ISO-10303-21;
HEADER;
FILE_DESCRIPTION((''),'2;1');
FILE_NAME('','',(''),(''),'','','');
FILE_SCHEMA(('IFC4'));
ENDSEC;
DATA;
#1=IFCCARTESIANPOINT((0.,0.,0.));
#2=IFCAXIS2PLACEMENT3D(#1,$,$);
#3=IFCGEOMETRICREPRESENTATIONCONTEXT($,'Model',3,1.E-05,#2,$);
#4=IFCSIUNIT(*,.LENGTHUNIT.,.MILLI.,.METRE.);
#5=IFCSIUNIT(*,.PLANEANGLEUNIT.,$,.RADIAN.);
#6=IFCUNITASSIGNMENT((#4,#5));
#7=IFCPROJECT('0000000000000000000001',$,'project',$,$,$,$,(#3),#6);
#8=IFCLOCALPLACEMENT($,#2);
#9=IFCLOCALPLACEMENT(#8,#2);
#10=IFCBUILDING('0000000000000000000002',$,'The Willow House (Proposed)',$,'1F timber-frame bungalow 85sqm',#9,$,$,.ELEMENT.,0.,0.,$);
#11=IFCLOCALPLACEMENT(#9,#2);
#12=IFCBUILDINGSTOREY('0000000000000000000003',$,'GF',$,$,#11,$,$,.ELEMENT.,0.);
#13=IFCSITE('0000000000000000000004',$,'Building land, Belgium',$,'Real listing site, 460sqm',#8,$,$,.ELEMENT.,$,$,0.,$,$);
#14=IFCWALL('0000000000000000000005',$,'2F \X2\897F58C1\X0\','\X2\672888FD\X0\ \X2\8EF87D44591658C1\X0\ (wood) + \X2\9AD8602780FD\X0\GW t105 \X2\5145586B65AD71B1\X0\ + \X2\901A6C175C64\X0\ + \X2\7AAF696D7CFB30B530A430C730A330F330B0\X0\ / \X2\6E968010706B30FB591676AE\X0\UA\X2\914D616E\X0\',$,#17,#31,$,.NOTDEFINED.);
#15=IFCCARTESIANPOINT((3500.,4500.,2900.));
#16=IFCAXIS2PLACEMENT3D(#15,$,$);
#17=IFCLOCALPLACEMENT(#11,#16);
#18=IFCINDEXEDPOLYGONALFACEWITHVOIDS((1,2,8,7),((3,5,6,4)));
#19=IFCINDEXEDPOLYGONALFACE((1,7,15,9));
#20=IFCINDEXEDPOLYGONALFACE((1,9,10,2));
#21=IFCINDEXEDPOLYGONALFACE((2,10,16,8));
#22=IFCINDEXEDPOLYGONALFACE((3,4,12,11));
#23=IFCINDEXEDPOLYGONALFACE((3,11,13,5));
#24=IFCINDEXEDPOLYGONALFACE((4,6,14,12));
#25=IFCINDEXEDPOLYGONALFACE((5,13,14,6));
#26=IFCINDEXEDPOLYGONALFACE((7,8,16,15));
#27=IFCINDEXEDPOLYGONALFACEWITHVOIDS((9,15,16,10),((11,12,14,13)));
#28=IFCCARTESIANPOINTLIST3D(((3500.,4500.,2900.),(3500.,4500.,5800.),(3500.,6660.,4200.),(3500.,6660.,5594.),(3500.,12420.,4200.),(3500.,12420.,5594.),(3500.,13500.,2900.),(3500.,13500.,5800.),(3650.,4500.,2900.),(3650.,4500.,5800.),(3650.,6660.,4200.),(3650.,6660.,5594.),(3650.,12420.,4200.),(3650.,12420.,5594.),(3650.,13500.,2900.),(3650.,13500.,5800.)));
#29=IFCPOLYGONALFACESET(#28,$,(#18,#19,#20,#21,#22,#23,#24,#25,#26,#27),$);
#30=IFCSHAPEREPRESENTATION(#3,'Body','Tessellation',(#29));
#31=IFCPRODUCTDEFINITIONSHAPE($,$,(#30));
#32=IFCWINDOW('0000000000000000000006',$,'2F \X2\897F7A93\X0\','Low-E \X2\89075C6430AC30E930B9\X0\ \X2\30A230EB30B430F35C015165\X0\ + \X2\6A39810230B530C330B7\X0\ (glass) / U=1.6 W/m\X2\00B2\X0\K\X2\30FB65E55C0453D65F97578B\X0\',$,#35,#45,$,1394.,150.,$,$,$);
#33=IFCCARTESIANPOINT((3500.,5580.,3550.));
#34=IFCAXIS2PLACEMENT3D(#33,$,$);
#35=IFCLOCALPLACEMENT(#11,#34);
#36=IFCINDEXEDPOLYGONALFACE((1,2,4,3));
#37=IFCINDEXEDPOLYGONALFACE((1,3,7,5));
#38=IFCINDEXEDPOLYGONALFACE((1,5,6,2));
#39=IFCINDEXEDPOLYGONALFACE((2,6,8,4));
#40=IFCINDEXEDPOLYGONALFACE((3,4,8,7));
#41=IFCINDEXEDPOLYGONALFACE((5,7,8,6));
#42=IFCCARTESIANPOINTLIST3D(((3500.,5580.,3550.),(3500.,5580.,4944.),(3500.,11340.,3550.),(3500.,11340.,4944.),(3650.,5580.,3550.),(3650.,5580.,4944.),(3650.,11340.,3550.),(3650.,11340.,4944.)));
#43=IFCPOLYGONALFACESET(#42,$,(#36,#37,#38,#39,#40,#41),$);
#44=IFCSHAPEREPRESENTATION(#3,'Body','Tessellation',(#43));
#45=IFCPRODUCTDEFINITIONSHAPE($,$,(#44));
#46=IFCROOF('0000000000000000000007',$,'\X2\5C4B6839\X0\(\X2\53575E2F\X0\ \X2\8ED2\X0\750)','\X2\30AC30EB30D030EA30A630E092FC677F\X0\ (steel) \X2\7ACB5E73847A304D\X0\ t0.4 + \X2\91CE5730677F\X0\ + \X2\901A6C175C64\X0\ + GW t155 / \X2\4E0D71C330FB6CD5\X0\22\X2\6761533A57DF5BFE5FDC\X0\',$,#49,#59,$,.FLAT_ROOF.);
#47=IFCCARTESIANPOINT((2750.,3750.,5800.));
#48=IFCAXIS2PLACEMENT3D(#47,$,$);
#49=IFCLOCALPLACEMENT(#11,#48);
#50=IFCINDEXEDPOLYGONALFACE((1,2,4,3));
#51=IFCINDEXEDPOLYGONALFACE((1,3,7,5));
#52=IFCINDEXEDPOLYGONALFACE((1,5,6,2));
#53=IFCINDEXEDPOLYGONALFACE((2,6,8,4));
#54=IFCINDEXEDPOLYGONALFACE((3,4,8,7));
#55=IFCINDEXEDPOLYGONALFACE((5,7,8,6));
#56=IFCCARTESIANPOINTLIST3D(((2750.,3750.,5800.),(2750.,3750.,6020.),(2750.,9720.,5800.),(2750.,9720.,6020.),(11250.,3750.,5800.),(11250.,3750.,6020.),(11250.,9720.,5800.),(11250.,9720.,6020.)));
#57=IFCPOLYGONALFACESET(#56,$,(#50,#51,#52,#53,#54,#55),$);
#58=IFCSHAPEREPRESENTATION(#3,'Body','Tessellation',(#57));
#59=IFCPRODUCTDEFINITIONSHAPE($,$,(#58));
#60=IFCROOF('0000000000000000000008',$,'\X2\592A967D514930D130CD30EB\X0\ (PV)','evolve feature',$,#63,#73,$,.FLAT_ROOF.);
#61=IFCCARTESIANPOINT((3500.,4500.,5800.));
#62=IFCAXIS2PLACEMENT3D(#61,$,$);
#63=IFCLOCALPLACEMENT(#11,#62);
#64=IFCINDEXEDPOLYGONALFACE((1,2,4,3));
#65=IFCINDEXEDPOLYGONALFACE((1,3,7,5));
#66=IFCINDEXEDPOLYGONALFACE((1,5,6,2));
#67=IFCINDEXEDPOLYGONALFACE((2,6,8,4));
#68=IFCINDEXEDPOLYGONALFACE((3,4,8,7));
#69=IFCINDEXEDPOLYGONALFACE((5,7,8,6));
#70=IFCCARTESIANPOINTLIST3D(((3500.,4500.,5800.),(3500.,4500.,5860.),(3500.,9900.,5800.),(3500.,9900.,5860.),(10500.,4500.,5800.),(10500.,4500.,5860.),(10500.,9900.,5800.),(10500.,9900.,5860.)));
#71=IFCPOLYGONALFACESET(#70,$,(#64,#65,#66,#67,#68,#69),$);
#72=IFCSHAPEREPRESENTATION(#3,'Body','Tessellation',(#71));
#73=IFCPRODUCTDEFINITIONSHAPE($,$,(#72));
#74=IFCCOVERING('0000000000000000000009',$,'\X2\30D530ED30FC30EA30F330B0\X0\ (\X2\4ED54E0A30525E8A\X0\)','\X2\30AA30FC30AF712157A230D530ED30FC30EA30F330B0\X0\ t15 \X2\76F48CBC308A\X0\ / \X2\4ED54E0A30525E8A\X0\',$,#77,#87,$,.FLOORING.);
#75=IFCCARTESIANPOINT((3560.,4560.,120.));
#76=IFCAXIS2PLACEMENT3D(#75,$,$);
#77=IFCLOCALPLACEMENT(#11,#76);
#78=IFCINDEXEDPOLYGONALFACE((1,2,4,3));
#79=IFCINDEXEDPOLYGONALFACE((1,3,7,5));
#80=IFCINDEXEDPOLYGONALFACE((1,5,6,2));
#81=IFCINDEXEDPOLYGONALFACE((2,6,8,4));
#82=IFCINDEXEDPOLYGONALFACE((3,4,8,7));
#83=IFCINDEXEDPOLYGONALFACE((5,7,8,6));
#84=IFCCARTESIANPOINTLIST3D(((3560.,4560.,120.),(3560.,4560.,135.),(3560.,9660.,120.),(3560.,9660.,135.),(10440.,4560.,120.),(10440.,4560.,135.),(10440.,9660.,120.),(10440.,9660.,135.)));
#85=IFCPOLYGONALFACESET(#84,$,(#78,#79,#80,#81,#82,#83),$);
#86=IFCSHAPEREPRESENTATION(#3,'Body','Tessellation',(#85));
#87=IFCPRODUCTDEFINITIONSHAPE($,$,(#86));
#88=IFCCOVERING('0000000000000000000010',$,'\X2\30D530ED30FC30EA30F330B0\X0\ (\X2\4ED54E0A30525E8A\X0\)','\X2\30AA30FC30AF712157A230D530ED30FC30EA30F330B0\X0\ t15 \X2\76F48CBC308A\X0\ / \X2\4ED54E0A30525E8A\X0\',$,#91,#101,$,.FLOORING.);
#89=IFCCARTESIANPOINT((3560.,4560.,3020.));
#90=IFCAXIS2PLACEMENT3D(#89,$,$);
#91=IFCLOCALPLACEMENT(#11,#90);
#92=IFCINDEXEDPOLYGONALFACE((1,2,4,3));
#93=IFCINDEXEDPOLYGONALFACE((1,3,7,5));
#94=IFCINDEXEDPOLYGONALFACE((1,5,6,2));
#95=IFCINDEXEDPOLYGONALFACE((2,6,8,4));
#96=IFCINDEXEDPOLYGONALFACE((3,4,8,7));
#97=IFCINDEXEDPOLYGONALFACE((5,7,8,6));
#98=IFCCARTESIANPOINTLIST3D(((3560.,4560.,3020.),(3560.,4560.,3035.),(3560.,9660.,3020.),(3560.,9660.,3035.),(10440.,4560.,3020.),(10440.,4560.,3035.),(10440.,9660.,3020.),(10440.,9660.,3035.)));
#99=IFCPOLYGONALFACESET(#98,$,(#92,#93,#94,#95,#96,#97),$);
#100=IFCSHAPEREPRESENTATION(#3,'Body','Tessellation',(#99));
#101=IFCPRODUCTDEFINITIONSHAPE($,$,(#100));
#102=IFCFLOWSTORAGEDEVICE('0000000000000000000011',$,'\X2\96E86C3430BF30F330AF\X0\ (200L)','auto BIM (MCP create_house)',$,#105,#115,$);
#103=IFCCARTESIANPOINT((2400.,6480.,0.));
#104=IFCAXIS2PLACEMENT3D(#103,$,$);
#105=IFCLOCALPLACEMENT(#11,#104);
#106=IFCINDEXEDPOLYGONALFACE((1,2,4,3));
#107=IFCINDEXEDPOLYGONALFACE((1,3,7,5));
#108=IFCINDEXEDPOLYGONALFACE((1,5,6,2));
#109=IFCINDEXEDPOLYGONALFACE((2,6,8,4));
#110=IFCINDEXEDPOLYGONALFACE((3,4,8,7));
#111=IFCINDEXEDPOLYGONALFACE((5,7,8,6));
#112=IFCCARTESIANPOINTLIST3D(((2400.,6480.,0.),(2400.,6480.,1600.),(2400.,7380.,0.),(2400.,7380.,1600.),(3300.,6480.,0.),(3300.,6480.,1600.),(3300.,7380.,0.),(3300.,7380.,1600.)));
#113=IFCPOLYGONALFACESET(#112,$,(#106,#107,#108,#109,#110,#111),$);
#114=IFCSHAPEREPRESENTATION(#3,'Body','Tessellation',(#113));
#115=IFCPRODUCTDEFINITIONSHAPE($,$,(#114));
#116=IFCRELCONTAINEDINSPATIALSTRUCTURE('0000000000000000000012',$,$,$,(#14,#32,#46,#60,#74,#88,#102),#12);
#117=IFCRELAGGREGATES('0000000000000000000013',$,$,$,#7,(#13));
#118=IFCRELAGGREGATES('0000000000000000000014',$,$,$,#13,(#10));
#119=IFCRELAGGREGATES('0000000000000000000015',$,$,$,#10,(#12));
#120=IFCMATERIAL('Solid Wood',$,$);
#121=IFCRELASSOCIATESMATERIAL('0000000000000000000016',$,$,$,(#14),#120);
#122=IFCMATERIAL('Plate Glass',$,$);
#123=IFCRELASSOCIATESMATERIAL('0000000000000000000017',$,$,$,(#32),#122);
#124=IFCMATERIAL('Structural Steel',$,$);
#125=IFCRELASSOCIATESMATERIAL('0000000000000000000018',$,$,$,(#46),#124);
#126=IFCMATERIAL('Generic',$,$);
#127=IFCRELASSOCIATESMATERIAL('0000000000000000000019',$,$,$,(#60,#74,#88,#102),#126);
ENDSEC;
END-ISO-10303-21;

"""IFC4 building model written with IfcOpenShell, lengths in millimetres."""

from ifc_helpers import new_model, si_unit, frame, frame_2d, origin, place, context, project, spatial, rectangle, extrude, material, element, fill, save


model = new_model("IFC4")

# Units and contexts
model_context = context("Model", 3, precision=1e-05, world=origin())
ifc_project = project(units=[si_unit("LENGTHUNIT", "METRE", prefix="MILLI"), si_unit("PLANEANGLEUNIT", "RADIAN")], contexts=[model_context])

# Site, building, storey
site_placement = place(None, origin())
site = spatial("IfcSite", under=ifc_project, at=site_placement, Name="Building land, Belgium", ObjectType="Real listing site, 460sqm", CompositionType="ELEMENT", RefElevation=0.0)
building_placement = place(site_placement, origin())
building = spatial("IfcBuilding", under=site, at=building_placement, Name="The Willow House (Proposed)", ObjectType="1F timber-frame bungalow 85sqm", CompositionType="ELEMENT", ElevationOfRefHeight=0.0, ElevationOfTerrain=0.0)
storey_placement = place(building_placement, origin())
storey = spatial("IfcBuildingStorey", under=building, at=storey_placement, Name="GF", CompositionType="ELEMENT", Elevation=0.0)

# Shared definitions
ifc_material_1 = material(Name="Solid Wood")
ifc_material_2 = material(Name="Generic")

# Shared definitions
ifc_material_3 = material(Name="Plate Glass")

# Wall, opening, window
wall_1_placement = place(storey_placement, frame((3500.0, 4500.0, 2900.0)))
wall_1 = element("IfcWall", 1, at=wall_1_placement, inside=storey, material=ifc_material_1, Name="2F 西壁", Description="木製 軸組外壁 (wood) + 高性能GW t105 充填断熱 + 通気層 + 窯業系サイディング / 準耐火・外皮UA配慮", PredefinedType="NOTDEFINED", context=model_context, shape_type="SweptSolid", body=[
    extrude(rectangle(XDim=150.0, YDim=9000.0, at=frame_2d((75.0, 4500.0))), frame((3500.0, 4500.0, 2900.0)), (0.0, 0.0, 1.0), 2900.0),
])
opening_1_placement = place(storey_placement, frame((3500.0, 5580.0, 3550.0)))
opening_1 = element("IfcOpeningElement", 2, at=opening_1_placement, cuts=wall_1, PredefinedType="NOTDEFINED", context=model_context, shape_type="SweptSolid", body=[
    extrude(rectangle(XDim=150.0, YDim=5760.0, at=frame_2d((75.0, 2880.0))), frame((3500.0, 5580.0, 3550.0)), (0.0, 0.0, 1.0), 1394.0),
])
window_1_placement = place(storey_placement, frame((3500.0, 5580.0, 3550.0)))
window_1 = element("IfcWindow", 3, at=window_1_placement, inside=storey, material=ifc_material_3, Name="2F 西窓", Description="Low-E 複層ガラス アルゴン封入 + 樹脂サッシ (glass) / U=1.6 W/m²K・日射取得型", OverallHeight=1394.0, OverallWidth=150.0, context=model_context, shape_type="SweptSolid", body=[
    extrude(rectangle(XDim=150.0, YDim=5760.0, at=frame_2d((75.0, 2880.0))), frame((3500.0, 5580.0, 3550.0)), (0.0, 0.0, 1.0), 1394.0),
])
fill(opening_1, window_1)

# Roofs
ifc_material_4 = material(Name="Structural Steel")
for number, where, name in (
    (4, (2750.0, 3750.0, 5800.0), "屋根(南帯 軒750)"),
):
    element("IfcRoof", number, at=place(storey_placement, frame(where)), inside=storey, material=ifc_material_4, Name=name, Description="ガルバリウム鋼板 (steel) 立平葺き t0.4 + 野地板 + 通気層 + GW t155 / 不燃・法22条区域対応", PredefinedType="FLAT_ROOF", context=model_context, shape_type="SweptSolid", body=[
        extrude(rectangle(XDim=8500.0, YDim=5970.0, at=frame_2d((4250.0, 2985.0))), frame((2750.0, 3750.0, 5800.0)), (0.0, 0.0, 1.0), 220.0),
    ])
roof_placement = place(storey_placement, frame((3500.0, 4500.0, 5800.0)))
element("IfcRoof", 5, at=roof_placement, inside=storey, material=ifc_material_2, Name="太陽光パネル (PV)", Description="evolve feature", PredefinedType="FLAT_ROOF", context=model_context, shape_type="SweptSolid", body=[
    extrude(rectangle(XDim=7000.0, YDim=5400.0, at=frame_2d((3500.0, 2700.0))), frame((3500.0, 4500.0, 5800.0)), (0.0, 0.0, 1.0), 60.0),
])

# Coverings
covering_1_placement = place(storey_placement, frame((3560.0, 4560.0, 120.0)))
element("IfcCovering", 6, at=covering_1_placement, inside=storey, material=ifc_material_2, Name="フローリング (仕上げ床)", Description="オーク無垢フローリング t15 直貼り / 仕上げ床", PredefinedType="FLOORING", context=model_context, shape_type="SweptSolid", body=[
    extrude(rectangle(XDim=6880.0, YDim=5100.0, at=frame_2d((3440.0, 2550.0))), frame((3560.0, 4560.0, 120.0)), (0.0, 0.0, 1.0), 15.0),
])
covering_2_placement = place(storey_placement, frame((3560.0, 4560.0, 3020.0)))
element("IfcCovering", 7, at=covering_2_placement, inside=storey, material=ifc_material_2, Name="フローリング (仕上げ床)", Description="オーク無垢フローリング t15 直貼り / 仕上げ床", PredefinedType="FLOORING", context=model_context, shape_type="SweptSolid", body=[
    extrude(rectangle(XDim=6880.0, YDim=5100.0, at=frame_2d((3440.0, 2550.0))), frame((3560.0, 4560.0, 3020.0)), (0.0, 0.0, 1.0), 15.0),
])

# Flow storage device
flow_storage_device_placement = place(storey_placement, frame((2400.0, 6480.0, 0.0)))
element("IfcFlowStorageDevice", 8, at=flow_storage_device_placement, inside=storey, material=ifc_material_2, Name="雨水タンク (200L)", Description="auto BIM (MCP create_house)", context=model_context, shape_type="SweptSolid", body=[
    extrude(rectangle(XDim=900.0, YDim=900.0, at=frame_2d((450.0, 450.0))), frame((2400.0, 6480.0, 0.0)), (0.0, 0.0, 1.0), 1600.0),
])

save(model, "model.ifc")
